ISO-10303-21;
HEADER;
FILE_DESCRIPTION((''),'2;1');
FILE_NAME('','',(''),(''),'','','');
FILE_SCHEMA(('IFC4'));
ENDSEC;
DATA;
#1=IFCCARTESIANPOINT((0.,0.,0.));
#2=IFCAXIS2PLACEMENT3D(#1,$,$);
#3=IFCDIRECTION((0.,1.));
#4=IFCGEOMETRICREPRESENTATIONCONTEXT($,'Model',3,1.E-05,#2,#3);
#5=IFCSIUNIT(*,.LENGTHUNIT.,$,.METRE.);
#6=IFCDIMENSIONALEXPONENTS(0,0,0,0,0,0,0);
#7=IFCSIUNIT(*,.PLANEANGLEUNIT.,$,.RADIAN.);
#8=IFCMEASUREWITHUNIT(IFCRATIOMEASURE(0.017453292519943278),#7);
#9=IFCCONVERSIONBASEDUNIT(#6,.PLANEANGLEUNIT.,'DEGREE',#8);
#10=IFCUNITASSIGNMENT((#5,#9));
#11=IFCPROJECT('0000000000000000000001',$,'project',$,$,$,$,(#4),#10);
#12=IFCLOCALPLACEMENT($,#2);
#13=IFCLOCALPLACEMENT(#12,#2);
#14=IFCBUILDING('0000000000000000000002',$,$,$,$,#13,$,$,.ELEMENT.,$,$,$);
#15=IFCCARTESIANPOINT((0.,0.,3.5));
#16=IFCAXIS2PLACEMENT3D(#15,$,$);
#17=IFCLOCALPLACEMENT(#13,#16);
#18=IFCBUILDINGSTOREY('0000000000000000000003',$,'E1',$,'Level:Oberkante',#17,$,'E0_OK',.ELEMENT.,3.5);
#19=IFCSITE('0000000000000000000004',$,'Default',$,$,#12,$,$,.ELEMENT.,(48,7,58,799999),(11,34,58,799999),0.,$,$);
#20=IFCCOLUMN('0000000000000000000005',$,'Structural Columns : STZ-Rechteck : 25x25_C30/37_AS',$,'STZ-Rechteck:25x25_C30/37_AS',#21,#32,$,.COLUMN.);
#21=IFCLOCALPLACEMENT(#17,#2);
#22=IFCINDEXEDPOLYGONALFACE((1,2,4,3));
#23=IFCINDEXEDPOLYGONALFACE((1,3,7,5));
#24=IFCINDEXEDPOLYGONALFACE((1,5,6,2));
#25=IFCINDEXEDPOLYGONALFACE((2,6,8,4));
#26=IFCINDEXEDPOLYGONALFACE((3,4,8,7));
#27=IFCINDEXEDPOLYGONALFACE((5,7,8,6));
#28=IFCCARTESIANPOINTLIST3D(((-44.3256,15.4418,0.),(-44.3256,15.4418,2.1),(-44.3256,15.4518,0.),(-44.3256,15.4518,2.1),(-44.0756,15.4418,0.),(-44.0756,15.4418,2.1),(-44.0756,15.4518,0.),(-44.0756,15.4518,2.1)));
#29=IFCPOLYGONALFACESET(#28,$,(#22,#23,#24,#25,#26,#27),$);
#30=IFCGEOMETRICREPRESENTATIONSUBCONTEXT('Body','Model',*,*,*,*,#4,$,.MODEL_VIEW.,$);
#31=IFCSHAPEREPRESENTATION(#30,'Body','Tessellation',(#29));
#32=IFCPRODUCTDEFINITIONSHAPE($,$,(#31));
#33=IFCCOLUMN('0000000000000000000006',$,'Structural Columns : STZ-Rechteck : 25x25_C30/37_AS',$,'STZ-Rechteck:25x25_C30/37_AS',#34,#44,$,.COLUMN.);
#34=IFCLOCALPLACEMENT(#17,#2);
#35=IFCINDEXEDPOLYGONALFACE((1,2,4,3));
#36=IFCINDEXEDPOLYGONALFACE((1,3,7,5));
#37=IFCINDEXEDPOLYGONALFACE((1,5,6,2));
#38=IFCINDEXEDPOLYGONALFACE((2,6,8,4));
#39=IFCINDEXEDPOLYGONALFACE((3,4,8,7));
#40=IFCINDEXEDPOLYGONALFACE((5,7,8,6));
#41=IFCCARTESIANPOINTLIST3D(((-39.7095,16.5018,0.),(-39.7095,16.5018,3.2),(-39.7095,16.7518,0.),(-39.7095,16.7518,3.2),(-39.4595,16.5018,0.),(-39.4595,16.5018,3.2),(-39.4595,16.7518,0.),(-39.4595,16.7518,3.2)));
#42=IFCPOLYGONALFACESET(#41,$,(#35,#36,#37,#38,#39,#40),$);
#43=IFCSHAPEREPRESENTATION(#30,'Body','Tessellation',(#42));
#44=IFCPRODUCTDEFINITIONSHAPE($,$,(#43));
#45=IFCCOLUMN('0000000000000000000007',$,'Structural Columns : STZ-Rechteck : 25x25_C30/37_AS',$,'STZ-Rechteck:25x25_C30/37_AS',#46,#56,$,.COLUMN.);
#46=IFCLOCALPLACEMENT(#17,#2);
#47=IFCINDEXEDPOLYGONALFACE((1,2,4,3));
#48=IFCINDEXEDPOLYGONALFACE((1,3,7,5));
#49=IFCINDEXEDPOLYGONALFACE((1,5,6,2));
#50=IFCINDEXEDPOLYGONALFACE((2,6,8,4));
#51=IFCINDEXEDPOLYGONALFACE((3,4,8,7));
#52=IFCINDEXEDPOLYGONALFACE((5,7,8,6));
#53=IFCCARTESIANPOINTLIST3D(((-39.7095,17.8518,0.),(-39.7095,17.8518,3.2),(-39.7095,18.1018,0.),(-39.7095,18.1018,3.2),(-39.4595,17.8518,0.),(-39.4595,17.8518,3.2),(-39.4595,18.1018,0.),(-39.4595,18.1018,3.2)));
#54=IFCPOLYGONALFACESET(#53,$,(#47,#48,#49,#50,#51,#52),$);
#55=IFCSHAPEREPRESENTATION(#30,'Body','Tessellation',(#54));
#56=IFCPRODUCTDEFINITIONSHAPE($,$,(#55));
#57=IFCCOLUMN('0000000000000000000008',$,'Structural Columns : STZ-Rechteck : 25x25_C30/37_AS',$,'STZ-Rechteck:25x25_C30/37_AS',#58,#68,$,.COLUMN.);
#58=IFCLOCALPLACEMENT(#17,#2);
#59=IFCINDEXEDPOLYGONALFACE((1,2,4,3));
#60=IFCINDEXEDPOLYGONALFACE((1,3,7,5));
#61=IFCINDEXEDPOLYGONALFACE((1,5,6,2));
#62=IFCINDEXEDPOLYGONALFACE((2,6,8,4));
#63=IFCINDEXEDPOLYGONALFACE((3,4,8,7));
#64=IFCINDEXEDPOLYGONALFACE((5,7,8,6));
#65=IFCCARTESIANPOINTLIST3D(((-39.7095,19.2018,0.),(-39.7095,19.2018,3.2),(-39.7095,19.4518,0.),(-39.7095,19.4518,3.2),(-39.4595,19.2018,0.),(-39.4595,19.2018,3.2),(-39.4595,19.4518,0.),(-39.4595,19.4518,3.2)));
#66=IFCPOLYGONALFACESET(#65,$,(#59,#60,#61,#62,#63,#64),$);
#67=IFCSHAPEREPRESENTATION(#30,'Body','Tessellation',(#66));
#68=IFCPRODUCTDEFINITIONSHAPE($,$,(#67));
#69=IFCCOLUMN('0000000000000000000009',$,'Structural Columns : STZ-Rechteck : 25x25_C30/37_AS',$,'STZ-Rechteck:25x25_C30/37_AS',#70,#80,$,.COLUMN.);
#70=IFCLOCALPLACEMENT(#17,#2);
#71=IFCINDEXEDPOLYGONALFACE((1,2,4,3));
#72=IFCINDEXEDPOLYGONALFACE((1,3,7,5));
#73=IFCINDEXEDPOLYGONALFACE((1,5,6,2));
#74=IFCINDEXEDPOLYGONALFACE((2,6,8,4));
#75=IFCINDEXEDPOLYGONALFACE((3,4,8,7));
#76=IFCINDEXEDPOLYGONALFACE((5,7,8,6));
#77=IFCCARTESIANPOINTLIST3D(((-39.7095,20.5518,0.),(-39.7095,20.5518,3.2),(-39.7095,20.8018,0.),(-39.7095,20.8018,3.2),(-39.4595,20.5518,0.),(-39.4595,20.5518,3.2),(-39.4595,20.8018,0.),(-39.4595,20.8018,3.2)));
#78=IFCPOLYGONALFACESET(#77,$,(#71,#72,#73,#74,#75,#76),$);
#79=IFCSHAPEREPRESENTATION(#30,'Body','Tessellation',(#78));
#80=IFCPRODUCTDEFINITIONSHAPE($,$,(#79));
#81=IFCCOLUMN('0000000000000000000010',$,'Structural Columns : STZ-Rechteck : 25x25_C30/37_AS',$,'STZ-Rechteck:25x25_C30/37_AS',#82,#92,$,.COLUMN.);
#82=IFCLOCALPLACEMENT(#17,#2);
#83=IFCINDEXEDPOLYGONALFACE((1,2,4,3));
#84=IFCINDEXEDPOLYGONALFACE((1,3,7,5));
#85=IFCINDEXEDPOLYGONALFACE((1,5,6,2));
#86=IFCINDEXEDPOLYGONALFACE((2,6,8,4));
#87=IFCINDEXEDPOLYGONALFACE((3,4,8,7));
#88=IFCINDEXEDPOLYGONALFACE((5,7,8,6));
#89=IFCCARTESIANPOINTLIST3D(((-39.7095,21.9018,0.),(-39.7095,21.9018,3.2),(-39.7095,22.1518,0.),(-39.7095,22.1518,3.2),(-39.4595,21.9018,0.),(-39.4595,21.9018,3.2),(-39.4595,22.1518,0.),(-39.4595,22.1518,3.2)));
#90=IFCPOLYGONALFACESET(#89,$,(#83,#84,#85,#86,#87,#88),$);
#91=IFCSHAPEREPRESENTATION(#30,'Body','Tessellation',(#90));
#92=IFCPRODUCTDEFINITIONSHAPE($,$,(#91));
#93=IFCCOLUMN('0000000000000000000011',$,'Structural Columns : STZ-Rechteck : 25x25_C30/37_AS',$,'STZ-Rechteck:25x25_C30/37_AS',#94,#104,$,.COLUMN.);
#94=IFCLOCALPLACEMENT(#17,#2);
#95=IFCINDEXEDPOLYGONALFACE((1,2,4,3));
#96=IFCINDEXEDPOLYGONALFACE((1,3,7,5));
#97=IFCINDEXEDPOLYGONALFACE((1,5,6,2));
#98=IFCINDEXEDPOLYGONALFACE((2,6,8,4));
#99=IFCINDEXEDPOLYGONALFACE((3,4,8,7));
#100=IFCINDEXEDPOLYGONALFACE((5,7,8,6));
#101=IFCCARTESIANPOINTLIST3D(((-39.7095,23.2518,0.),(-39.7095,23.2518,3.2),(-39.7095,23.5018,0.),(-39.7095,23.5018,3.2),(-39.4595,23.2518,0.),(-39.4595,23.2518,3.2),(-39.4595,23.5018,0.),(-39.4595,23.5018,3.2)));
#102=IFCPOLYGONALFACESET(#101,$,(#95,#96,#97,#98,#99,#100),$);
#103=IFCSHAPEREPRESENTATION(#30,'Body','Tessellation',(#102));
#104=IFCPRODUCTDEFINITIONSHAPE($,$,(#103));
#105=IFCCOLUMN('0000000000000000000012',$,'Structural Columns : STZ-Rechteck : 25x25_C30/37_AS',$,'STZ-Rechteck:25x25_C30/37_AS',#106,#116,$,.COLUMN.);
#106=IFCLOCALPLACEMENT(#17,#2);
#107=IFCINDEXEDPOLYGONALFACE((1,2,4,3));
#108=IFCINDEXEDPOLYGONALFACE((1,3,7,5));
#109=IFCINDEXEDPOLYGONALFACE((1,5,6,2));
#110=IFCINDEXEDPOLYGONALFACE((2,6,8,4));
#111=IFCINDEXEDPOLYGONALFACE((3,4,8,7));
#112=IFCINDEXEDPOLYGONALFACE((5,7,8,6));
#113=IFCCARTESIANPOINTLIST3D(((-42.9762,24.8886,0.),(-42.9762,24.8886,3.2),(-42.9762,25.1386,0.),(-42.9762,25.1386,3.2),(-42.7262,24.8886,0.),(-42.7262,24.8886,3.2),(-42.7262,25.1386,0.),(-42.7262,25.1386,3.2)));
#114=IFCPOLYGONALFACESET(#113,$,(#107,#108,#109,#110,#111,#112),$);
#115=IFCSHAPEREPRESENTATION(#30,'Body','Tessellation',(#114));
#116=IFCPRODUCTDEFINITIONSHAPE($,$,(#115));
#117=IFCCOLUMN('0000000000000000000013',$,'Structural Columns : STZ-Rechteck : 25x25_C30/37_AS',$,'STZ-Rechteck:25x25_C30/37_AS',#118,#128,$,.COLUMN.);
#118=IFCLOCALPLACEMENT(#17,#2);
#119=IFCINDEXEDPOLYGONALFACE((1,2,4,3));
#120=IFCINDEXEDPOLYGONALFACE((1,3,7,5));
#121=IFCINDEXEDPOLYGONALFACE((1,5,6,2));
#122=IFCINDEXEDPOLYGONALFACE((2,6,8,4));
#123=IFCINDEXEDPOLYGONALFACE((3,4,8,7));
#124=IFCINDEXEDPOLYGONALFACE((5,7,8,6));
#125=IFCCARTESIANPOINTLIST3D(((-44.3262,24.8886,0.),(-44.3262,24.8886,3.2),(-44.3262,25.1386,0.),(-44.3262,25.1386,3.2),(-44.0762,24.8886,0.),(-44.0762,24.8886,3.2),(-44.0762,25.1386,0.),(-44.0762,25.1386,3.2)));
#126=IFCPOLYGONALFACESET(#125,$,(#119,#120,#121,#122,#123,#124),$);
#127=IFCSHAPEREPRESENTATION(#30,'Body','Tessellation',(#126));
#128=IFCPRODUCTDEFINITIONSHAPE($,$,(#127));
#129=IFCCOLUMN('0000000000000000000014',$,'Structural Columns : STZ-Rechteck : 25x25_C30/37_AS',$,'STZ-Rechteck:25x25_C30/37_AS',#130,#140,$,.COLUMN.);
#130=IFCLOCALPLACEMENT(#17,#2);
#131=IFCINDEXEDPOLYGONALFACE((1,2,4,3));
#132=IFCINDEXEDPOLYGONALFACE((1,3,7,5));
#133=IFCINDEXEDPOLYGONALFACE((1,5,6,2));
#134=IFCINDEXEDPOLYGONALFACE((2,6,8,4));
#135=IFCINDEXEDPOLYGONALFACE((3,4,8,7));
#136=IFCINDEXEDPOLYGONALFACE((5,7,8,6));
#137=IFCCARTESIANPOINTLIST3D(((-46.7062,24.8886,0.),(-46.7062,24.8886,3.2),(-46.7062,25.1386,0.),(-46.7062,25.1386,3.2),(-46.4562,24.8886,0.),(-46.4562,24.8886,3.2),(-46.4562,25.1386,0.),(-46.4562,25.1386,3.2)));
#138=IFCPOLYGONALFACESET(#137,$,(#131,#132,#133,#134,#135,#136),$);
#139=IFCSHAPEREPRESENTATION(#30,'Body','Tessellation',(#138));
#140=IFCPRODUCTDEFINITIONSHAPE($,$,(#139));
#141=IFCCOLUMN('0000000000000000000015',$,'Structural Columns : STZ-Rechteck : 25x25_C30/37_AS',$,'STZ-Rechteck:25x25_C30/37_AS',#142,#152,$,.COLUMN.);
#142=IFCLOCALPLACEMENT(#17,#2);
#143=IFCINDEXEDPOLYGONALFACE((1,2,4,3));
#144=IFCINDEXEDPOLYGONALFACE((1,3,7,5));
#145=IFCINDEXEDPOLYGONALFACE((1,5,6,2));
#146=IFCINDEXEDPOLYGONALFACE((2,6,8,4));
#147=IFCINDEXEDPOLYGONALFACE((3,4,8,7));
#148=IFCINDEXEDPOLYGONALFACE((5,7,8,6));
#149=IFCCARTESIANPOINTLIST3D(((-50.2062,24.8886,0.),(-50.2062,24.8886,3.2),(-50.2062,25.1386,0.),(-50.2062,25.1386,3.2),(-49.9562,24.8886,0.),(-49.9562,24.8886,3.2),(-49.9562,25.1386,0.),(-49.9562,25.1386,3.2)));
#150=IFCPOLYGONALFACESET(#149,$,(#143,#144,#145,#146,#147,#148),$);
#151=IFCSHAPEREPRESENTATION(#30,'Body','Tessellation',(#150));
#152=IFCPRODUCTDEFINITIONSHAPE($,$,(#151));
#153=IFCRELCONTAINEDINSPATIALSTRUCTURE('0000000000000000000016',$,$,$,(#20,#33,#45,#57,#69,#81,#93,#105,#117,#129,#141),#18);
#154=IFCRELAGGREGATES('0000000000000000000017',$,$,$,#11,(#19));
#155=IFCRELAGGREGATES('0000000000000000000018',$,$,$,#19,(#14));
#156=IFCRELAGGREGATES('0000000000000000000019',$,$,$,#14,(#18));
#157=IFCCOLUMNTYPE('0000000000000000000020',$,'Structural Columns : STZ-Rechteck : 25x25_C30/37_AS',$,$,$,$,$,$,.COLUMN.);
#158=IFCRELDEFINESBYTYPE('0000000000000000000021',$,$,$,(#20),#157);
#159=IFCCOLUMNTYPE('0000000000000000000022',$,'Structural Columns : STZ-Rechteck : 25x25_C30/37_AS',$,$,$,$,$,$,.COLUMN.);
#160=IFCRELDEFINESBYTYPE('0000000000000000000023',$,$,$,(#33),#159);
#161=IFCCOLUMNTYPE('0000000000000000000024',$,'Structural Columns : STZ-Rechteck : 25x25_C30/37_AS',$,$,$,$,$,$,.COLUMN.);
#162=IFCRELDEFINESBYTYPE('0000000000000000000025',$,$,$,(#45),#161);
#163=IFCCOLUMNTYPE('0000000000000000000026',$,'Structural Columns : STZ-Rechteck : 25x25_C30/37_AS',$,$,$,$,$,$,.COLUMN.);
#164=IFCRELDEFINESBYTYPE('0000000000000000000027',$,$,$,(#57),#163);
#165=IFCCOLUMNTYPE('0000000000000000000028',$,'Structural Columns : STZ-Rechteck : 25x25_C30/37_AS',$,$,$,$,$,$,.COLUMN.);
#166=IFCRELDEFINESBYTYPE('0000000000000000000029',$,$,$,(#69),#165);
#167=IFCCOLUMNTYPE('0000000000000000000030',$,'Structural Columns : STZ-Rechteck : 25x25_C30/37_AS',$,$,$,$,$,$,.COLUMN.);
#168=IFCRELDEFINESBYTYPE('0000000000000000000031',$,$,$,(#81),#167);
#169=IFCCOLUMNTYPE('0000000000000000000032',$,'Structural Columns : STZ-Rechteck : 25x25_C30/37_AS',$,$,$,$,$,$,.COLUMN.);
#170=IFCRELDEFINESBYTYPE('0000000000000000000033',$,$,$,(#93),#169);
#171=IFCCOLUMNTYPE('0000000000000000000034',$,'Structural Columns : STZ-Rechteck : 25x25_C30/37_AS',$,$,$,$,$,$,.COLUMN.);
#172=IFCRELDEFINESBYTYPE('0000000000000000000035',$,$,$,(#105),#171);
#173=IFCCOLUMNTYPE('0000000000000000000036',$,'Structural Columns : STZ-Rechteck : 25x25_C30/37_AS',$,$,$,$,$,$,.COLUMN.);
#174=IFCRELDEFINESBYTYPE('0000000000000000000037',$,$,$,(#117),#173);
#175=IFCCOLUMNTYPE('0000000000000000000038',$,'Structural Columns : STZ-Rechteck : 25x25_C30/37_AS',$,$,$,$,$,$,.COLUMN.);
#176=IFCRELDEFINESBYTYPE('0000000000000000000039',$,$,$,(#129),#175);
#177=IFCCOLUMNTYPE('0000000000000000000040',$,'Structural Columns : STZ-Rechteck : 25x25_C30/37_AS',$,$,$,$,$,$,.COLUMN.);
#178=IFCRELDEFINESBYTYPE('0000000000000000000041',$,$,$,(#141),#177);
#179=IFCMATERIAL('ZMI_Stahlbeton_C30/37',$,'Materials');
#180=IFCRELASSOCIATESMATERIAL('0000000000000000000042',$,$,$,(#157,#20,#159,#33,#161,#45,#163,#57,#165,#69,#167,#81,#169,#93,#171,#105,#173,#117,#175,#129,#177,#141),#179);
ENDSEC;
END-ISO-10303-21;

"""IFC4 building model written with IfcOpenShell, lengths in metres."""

from ifc_helpers import new_model, entity, si_unit, converted_unit, direction, frame, origin, place, context, subcontext, project, spatial, indexed_curve, outline, extrude, source, transform, mapped, material, type_object, type_shapes, element, save


model = new_model("IFC4")

# Units and contexts
model_context = context("Model", 3, precision=1e-05, world=origin(), true_north=direction((0.0, 1.0)))
body_context = subcontext(model_context, "Body", "Model", "MODEL_VIEW")
ifc_project = project(units=[si_unit("LENGTHUNIT", "METRE"), converted_unit("PLANEANGLEUNIT", "DEGREE", entity("IfcRatioMeasure", 0.017453292519943278), si_unit("PLANEANGLEUNIT", "RADIAN"), dimensions=[0, 0, 0, 0, 0, 0, 0])], contexts=[model_context])

# Site, building, storey
site_placement = place(None, origin())
site = spatial("IfcSite", under=ifc_project, at=site_placement, Name="Default", CompositionType="ELEMENT", RefLatitude=(48, 7, 58, 799999), RefLongitude=(11, 34, 58, 799999), RefElevation=0.0)
building_placement = place(site_placement, origin())
building = spatial("IfcBuilding", under=site, at=building_placement, CompositionType="ELEMENT")
storey_placement = place(building_placement, frame((0.0, 0.0, 3.5)))
storey = spatial("IfcBuildingStorey", under=building, at=storey_placement, Name="E1", ObjectType="Level:Oberkante", LongName="E0_OK", CompositionType="ELEMENT", Elevation=3.5)

# Columns
ifc_material_1 = material(Name="ZMI_Stahlbeton_C30/37", Category="Materials")
column_type_1 = type_object("IfcColumnType", Name="Structural Columns : STZ-Rechteck : 25x25_C30/37_AS", PredefinedType="COLUMN", material=ifc_material_1)
shared_shape_1 = source(origin(), body_context, "Body", "SweptSolid", [
    extrude(outline(indexed_curve([(-0.005, -0.125), (0.005, -0.125), (0.005, 0.125), (-0.005, 0.125), (-0.005, -0.125)], self_intersect=False)), frame((-44.2006, 15.4468, 3.5), z_axis=(0.0, 0.0, 1.0), x_axis=(0.0, -1.0, 0.0)), (0.0, 0.0, 1.0), 2.1),
])
type_shapes(column_type_1, [shared_shape_1])
column_1_placement = place(storey_placement, frame((0.0, 0.0, -3.5)))
element("IfcColumn", 1, at=column_1_placement, inside=storey, type_object=column_type_1, material=ifc_material_1, Name="Structural Columns : STZ-Rechteck : 25x25_C30/37_AS", ObjectType="STZ-Rechteck:25x25_C30/37_AS", PredefinedType="COLUMN", context=body_context, shape_type="MappedRepresentation", body=[
    mapped(shared_shape_1, transform((0.0, 0.0, 0.0), scale=1.0)),
])
column_type_2 = type_object("IfcColumnType", Name="Structural Columns : STZ-Rechteck : 25x25_C30/37_AS", PredefinedType="COLUMN", material=ifc_material_1)
shared_shape_2 = source(origin(), body_context, "Body", "SweptSolid", [
    extrude(outline(indexed_curve([(-0.125, -0.125), (0.125, -0.125), (0.125, 0.125), (-0.125, 0.125), (-0.125, -0.125)], self_intersect=False)), frame((-39.5845, 16.6268, 3.5), z_axis=(0.0, 0.0, 1.0), x_axis=(0.0, -1.0, 0.0)), (0.0, 0.0, 1.0), 3.2),
])
type_shapes(column_type_2, [shared_shape_2])
column_2_placement = place(storey_placement, frame((0.0, 0.0, -3.5)))
element("IfcColumn", 2, at=column_2_placement, inside=storey, type_object=column_type_2, material=ifc_material_1, Name="Structural Columns : STZ-Rechteck : 25x25_C30/37_AS", ObjectType="STZ-Rechteck:25x25_C30/37_AS", PredefinedType="COLUMN", context=body_context, shape_type="MappedRepresentation", body=[
    mapped(shared_shape_2, transform((0.0, 0.0, 0.0), scale=1.0)),
])
column_type_3 = type_object("IfcColumnType", Name="Structural Columns : STZ-Rechteck : 25x25_C30/37_AS", PredefinedType="COLUMN", material=ifc_material_1)
shared_shape_3 = source(origin(), body_context, "Body", "SweptSolid", [
    extrude(outline(indexed_curve([(-0.125, -0.125), (0.125, -0.125), (0.125, 0.125), (-0.125, 0.125), (-0.125, -0.125)], self_intersect=False)), frame((-39.5845, 17.9768, 3.5), z_axis=(0.0, 0.0, 1.0), x_axis=(0.0, -1.0, 0.0)), (0.0, 0.0, 1.0), 3.2),
])
type_shapes(column_type_3, [shared_shape_3])
column_3_placement = place(storey_placement, frame((0.0, 0.0, -3.5)))
element("IfcColumn", 3, at=column_3_placement, inside=storey, type_object=column_type_3, material=ifc_material_1, Name="Structural Columns : STZ-Rechteck : 25x25_C30/37_AS", ObjectType="STZ-Rechteck:25x25_C30/37_AS", PredefinedType="COLUMN", context=body_context, shape_type="MappedRepresentation", body=[
    mapped(shared_shape_3, transform((0.0, 0.0, 0.0), scale=1.0)),
])
column_type_4 = type_object("IfcColumnType", Name="Structural Columns : STZ-Rechteck : 25x25_C30/37_AS", PredefinedType="COLUMN", material=ifc_material_1)
shared_shape_4 = source(origin(), body_context, "Body", "SweptSolid", [
    extrude(outline(indexed_curve([(-0.125, -0.125), (0.125, -0.125), (0.125, 0.125), (-0.125, 0.125), (-0.125, -0.125)], self_intersect=False)), frame((-39.5845, 19.3268, 3.5), z_axis=(0.0, 0.0, 1.0), x_axis=(0.0, -1.0, 0.0)), (0.0, 0.0, 1.0), 3.2),
])
type_shapes(column_type_4, [shared_shape_4])
column_4_placement = place(storey_placement, frame((0.0, 0.0, -3.5)))
element("IfcColumn", 4, at=column_4_placement, inside=storey, type_object=column_type_4, material=ifc_material_1, Name="Structural Columns : STZ-Rechteck : 25x25_C30/37_AS", ObjectType="STZ-Rechteck:25x25_C30/37_AS", PredefinedType="COLUMN", context=body_context, shape_type="MappedRepresentation", body=[
    mapped(shared_shape_4, transform((0.0, 0.0, 0.0), scale=1.0)),
])
column_type_5 = type_object("IfcColumnType", Name="Structural Columns : STZ-Rechteck : 25x25_C30/37_AS", PredefinedType="COLUMN", material=ifc_material_1)
shared_shape_5 = source(origin(), body_context, "Body", "SweptSolid", [
    extrude(outline(indexed_curve([(-0.125, -0.125), (0.125, -0.125), (0.125, 0.125), (-0.125, 0.125), (-0.125, -0.125)], self_intersect=False)), frame((-39.5845, 20.6768, 3.5), z_axis=(0.0, 0.0, 1.0), x_axis=(0.0, -1.0, 0.0)), (0.0, 0.0, 1.0), 3.2),
])
type_shapes(column_type_5, [shared_shape_5])
column_5_placement = place(storey_placement, frame((0.0, 0.0, -3.5)))
element("IfcColumn", 5, at=column_5_placement, inside=storey, type_object=column_type_5, material=ifc_material_1, Name="Structural Columns : STZ-Rechteck : 25x25_C30/37_AS", ObjectType="STZ-Rechteck:25x25_C30/37_AS", PredefinedType="COLUMN", context=body_context, shape_type="MappedRepresentation", body=[
    mapped(shared_shape_5, transform((0.0, 0.0, 0.0), scale=1.0)),
])
column_type_6 = type_object("IfcColumnType", Name="Structural Columns : STZ-Rechteck : 25x25_C30/37_AS", PredefinedType="COLUMN", material=ifc_material_1)
shared_shape_6 = source(origin(), body_context, "Body", "SweptSolid", [
    extrude(outline(indexed_curve([(-0.125, -0.125), (0.125, -0.125), (0.125, 0.125), (-0.125, 0.125), (-0.125, -0.125)], self_intersect=False)), frame((-39.5845, 22.0268, 3.5), z_axis=(0.0, 0.0, 1.0), x_axis=(0.0, -1.0, 0.0)), (0.0, 0.0, 1.0), 3.2),
])
type_shapes(column_type_6, [shared_shape_6])
column_6_placement = place(storey_placement, frame((0.0, 0.0, -3.5)))
element("IfcColumn", 6, at=column_6_placement, inside=storey, type_object=column_type_6, material=ifc_material_1, Name="Structural Columns : STZ-Rechteck : 25x25_C30/37_AS", ObjectType="STZ-Rechteck:25x25_C30/37_AS", PredefinedType="COLUMN", context=body_context, shape_type="MappedRepresentation", body=[
    mapped(shared_shape_6, transform((0.0, 0.0, 0.0), scale=1.0)),
])
column_type_7 = type_object("IfcColumnType", Name="Structural Columns : STZ-Rechteck : 25x25_C30/37_AS", PredefinedType="COLUMN", material=ifc_material_1)
shared_shape_7 = source(origin(), body_context, "Body", "SweptSolid", [
    extrude(outline(indexed_curve([(-0.125, -0.125), (0.125, -0.125), (0.125, 0.125), (-0.125, 0.125), (-0.125, -0.125)], self_intersect=False)), frame((-39.5845, 23.3768, 3.5), z_axis=(0.0, 0.0, 1.0), x_axis=(0.0, -1.0, 0.0)), (0.0, 0.0, 1.0), 3.2),
])
type_shapes(column_type_7, [shared_shape_7])
column_7_placement = place(storey_placement, frame((0.0, 0.0, -3.5)))
element("IfcColumn", 7, at=column_7_placement, inside=storey, type_object=column_type_7, material=ifc_material_1, Name="Structural Columns : STZ-Rechteck : 25x25_C30/37_AS", ObjectType="STZ-Rechteck:25x25_C30/37_AS", PredefinedType="COLUMN", context=body_context, shape_type="MappedRepresentation", body=[
    mapped(shared_shape_7, transform((0.0, 0.0, 0.0), scale=1.0)),
])
column_type_8 = type_object("IfcColumnType", Name="Structural Columns : STZ-Rechteck : 25x25_C30/37_AS", PredefinedType="COLUMN", material=ifc_material_1)
shared_shape_8 = source(origin(), body_context, "Body", "SweptSolid", [
    extrude(outline(indexed_curve([(-0.125, -0.125), (0.125, -0.125), (0.125, 0.125), (-0.125, 0.125), (-0.125, -0.125)], self_intersect=False)), frame((-42.8512, 25.0136, 3.5), z_axis=(0.0, 0.0, 1.0), x_axis=(0.0, -1.0, 0.0)), (0.0, 0.0, 1.0), 3.2),
])
type_shapes(column_type_8, [shared_shape_8])
column_8_placement = place(storey_placement, frame((0.0, 0.0, -3.5)))
element("IfcColumn", 8, at=column_8_placement, inside=storey, type_object=column_type_8, material=ifc_material_1, Name="Structural Columns : STZ-Rechteck : 25x25_C30/37_AS", ObjectType="STZ-Rechteck:25x25_C30/37_AS", PredefinedType="COLUMN", context=body_context, shape_type="MappedRepresentation", body=[
    mapped(shared_shape_8, transform((0.0, 0.0, 0.0), scale=1.0)),
])
column_type_9 = type_object("IfcColumnType", Name="Structural Columns : STZ-Rechteck : 25x25_C30/37_AS", PredefinedType="COLUMN", material=ifc_material_1)
shared_shape_9 = source(origin(), body_context, "Body", "SweptSolid", [
    extrude(outline(indexed_curve([(-0.125, -0.125), (0.125, -0.125), (0.125, 0.125), (-0.125, 0.125), (-0.125, -0.125)], self_intersect=False)), frame((-44.2012, 25.0136, 3.5), z_axis=(0.0, 0.0, 1.0), x_axis=(0.0, -1.0, 0.0)), (0.0, 0.0, 1.0), 3.2),
])
type_shapes(column_type_9, [shared_shape_9])
column_9_placement = place(storey_placement, frame((0.0, 0.0, -3.5)))
element("IfcColumn", 9, at=column_9_placement, inside=storey, type_object=column_type_9, material=ifc_material_1, Name="Structural Columns : STZ-Rechteck : 25x25_C30/37_AS", ObjectType="STZ-Rechteck:25x25_C30/37_AS", PredefinedType="COLUMN", context=body_context, shape_type="MappedRepresentation", body=[
    mapped(shared_shape_9, transform((0.0, 0.0, 0.0), scale=1.0)),
])
column_type_10 = type_object("IfcColumnType", Name="Structural Columns : STZ-Rechteck : 25x25_C30/37_AS", PredefinedType="COLUMN", material=ifc_material_1)
shared_shape_10 = source(origin(), body_context, "Body", "SweptSolid", [
    extrude(outline(indexed_curve([(-0.125, -0.125), (0.125, -0.125), (0.125, 0.125), (-0.125, 0.125), (-0.125, -0.125)], self_intersect=False)), frame((-46.5812, 25.0136, 3.5), z_axis=(0.0, 0.0, 1.0), x_axis=(0.0, -1.0, 0.0)), (0.0, 0.0, 1.0), 3.2),
])
type_shapes(column_type_10, [shared_shape_10])
column_10_placement = place(storey_placement, frame((0.0, 0.0, -3.5)))
element("IfcColumn", 10, at=column_10_placement, inside=storey, type_object=column_type_10, material=ifc_material_1, Name="Structural Columns : STZ-Rechteck : 25x25_C30/37_AS", ObjectType="STZ-Rechteck:25x25_C30/37_AS", PredefinedType="COLUMN", context=body_context, shape_type="MappedRepresentation", body=[
    mapped(shared_shape_10, transform((0.0, 0.0, 0.0), scale=1.0)),
])
column_type_11 = type_object("IfcColumnType", Name="Structural Columns : STZ-Rechteck : 25x25_C30/37_AS", PredefinedType="COLUMN", material=ifc_material_1)
shared_shape_11 = source(origin(), body_context, "Body", "SweptSolid", [
    extrude(outline(indexed_curve([(-0.125, -0.125), (0.125, -0.125), (0.125, 0.125), (-0.125, 0.125), (-0.125, -0.125)], self_intersect=False)), frame((-50.0812, 25.0136, 3.5), z_axis=(0.0, 0.0, 1.0), x_axis=(0.0, -1.0, 0.0)), (0.0, 0.0, 1.0), 3.2),
])
type_shapes(column_type_11, [shared_shape_11])
column_11_placement = place(storey_placement, frame((0.0, 0.0, -3.5)))
element("IfcColumn", 11, at=column_11_placement, inside=storey, type_object=column_type_11, material=ifc_material_1, Name="Structural Columns : STZ-Rechteck : 25x25_C30/37_AS", ObjectType="STZ-Rechteck:25x25_C30/37_AS", PredefinedType="COLUMN", context=body_context, shape_type="MappedRepresentation", body=[
    mapped(shared_shape_11, transform((0.0, 0.0, 0.0), scale=1.0)),
])

save(model, "model.ifc")
